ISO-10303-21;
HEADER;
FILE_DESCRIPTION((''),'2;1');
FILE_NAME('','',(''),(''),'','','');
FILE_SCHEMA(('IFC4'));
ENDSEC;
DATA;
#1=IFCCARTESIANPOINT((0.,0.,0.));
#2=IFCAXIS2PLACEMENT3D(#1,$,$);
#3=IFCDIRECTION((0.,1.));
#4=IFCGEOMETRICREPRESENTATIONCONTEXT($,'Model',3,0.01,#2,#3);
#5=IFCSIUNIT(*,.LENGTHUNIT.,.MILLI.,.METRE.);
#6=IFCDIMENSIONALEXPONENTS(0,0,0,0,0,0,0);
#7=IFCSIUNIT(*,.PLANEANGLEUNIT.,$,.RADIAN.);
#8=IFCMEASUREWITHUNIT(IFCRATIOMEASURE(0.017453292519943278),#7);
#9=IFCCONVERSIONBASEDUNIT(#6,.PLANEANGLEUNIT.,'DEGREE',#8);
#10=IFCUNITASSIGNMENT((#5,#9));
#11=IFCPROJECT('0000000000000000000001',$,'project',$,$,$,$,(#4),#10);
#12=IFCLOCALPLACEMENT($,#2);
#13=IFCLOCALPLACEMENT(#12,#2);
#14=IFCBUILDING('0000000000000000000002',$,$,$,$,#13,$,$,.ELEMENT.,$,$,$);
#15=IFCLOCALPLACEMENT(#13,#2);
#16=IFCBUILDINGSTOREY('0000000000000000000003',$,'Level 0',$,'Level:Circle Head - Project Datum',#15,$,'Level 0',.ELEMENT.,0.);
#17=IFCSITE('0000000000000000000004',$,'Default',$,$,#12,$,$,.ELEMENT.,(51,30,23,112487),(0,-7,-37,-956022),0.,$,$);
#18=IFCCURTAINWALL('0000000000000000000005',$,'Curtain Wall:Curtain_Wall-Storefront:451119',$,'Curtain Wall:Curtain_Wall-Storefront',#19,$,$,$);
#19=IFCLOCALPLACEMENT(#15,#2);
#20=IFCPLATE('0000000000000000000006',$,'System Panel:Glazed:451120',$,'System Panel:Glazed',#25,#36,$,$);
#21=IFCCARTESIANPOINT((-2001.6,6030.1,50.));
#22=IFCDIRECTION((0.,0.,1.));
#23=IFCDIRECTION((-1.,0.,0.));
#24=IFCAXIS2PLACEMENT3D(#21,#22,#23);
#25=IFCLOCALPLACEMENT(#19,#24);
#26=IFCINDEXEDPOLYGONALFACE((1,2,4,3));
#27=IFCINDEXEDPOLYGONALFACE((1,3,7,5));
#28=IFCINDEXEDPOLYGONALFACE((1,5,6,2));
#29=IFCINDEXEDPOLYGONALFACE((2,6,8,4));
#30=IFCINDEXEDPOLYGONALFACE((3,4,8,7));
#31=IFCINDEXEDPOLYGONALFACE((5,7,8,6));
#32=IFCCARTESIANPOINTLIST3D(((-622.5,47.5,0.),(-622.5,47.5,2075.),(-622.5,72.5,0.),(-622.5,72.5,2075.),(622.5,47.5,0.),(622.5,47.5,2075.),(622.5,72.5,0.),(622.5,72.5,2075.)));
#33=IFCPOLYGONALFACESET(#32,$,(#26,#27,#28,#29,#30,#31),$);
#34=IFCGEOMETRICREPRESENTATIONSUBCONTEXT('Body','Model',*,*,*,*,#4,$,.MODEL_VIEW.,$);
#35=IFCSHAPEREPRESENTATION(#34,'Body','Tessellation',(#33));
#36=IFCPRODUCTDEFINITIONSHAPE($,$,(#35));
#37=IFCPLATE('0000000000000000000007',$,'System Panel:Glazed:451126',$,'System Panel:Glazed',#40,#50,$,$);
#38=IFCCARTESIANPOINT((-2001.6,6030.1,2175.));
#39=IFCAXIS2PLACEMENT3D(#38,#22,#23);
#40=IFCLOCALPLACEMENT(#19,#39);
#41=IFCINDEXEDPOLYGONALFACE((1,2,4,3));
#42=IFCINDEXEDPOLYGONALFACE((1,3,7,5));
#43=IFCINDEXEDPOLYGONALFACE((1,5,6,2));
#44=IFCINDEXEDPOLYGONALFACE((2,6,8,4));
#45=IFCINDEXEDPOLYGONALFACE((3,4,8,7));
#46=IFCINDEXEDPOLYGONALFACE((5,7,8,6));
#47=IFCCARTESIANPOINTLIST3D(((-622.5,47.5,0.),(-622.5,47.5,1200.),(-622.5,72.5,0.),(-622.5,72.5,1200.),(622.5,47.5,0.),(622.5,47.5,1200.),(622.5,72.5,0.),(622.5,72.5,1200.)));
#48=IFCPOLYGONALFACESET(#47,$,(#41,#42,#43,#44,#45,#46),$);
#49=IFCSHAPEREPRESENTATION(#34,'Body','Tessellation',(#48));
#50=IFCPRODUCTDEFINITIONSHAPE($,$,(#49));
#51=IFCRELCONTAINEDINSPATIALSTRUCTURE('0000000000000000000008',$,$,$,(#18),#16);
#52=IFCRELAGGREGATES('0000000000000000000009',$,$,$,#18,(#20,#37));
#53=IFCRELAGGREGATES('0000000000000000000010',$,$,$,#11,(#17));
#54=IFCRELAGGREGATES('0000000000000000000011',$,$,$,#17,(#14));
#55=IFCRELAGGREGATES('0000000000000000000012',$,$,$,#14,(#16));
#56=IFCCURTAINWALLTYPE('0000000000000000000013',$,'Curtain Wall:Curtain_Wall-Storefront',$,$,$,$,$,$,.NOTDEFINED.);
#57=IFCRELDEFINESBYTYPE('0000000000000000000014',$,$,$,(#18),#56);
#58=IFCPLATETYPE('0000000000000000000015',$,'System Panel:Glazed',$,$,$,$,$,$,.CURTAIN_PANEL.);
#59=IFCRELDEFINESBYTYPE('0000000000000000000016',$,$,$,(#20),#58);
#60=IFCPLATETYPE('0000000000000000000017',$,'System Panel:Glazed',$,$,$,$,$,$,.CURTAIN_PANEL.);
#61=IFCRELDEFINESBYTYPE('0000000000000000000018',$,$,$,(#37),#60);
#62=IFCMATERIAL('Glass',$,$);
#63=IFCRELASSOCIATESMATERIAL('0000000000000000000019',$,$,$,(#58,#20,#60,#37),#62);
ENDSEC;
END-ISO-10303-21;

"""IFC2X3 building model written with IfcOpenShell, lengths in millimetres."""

from ifc_helpers import new_model, entity, si_unit, converted_unit, direction, frame, origin, origin_2d_with_axis, place, context, subcontext, project, spatial, rectangle, extrude, source, transform, mapped, material, type_object, type_shapes, element, aggregate, save


model = new_model("IFC2X3")

# Units and contexts
model_context = context("Model", 3, precision=0.01, world=origin(), true_north=direction((0.0, 1.0)))
body_context = subcontext(model_context, "Body", "Model", "MODEL_VIEW")
ifc_project = project(units=[si_unit("LENGTHUNIT", "METRE", prefix="MILLI"), converted_unit("PLANEANGLEUNIT", "DEGREE", entity("IfcRatioMeasure", 0.017453292519943278), si_unit("PLANEANGLEUNIT", "RADIAN"), dimensions=[0, 0, 0, 0, 0, 0, 0])], contexts=[model_context])

# Site, building, storey
site_placement = place(None, origin())
site = spatial("IfcSite", under=ifc_project, at=site_placement, Name="Default", CompositionType="ELEMENT", RefLatitude=(51, 30, 23, 112487), RefLongitude=(0, -7, -37, -956022), RefElevation=0.0)
building_placement = place(site_placement, origin())
building = spatial("IfcBuilding", under=site, at=building_placement, CompositionType="ELEMENT")
storey_placement = place(building_placement, origin())
storey = spatial("IfcBuildingStorey", under=building, at=storey_placement, Name="Level 0", ObjectType="Level:Circle Head - Project Datum", LongName="Level 0", CompositionType="ELEMENT", Elevation=0.0)

# Curtain wall
curtain_wall_type = type_object("IfcCurtainWallType", Name="Curtain Wall:Curtain_Wall-Storefront", PredefinedType="NOTDEFINED")
curtain_wall_placement = place(storey_placement, origin())
curtain_wall = element("IfcCurtainWall", 1, at=curtain_wall_placement, inside=storey, type_object=curtain_wall_type, Name="Curtain Wall:Curtain_Wall-Storefront:451119", ObjectType="Curtain Wall:Curtain_Wall-Storefront")

# Plates
ifc_material_1 = material(Name="Glass")
plate_type_1 = type_object("IfcPlateType", Name="System Panel:Glazed", PredefinedType="CURTAIN_PANEL", material=ifc_material_1)
shared_shape_1 = source(origin(), body_context, "Body", "SweptSolid", [
    extrude(rectangle(XDim=25.0, YDim=1245.0, at=origin_2d_with_axis()), frame((0.0, 60.0, 0.0), z_axis=(0.0, 0.0, 1.0), x_axis=(0.0, 1.0, 0.0)), (0.0, 0.0, 1.0), 2075.0),
])
type_shapes(plate_type_1, [shared_shape_1])
plate_1_placement = place(curtain_wall_placement, frame((-2001.6, 6030.1, 50.0), z_axis=(0.0, 0.0, 1.0), x_axis=(-1.0, 0.0, 0.0)))
plate_1 = element("IfcPlate", 2, at=plate_1_placement, type_object=plate_type_1, material=ifc_material_1, Name="System Panel:Glazed:451120", ObjectType="System Panel:Glazed", context=body_context, shape_type="MappedRepresentation", body=[
    mapped(shared_shape_1, transform((0.0, 0.0, 0.0), scale=1.0)),
])
plate_type_2 = type_object("IfcPlateType", Name="System Panel:Glazed", PredefinedType="CURTAIN_PANEL", material=ifc_material_1)
shared_shape_2 = source(origin(), body_context, "Body", "SweptSolid", [
    extrude(rectangle(XDim=25.0, YDim=1245.0, at=origin_2d_with_axis()), frame((0.0, 60.0, 0.0), z_axis=(0.0, 0.0, 1.0), x_axis=(0.0, 1.0, 0.0)), (0.0, 0.0, 1.0), 1200.0),
])
type_shapes(plate_type_2, [shared_shape_2])
plate_2_placement = place(curtain_wall_placement, frame((-2001.6, 6030.1, 2175.0), z_axis=(0.0, 0.0, 1.0), x_axis=(-1.0, 0.0, 0.0)))
plate_2 = element("IfcPlate", 3, at=plate_2_placement, type_object=plate_type_2, material=ifc_material_1, Name="System Panel:Glazed:451126", ObjectType="System Panel:Glazed", context=body_context, shape_type="MappedRepresentation", body=[
    mapped(shared_shape_2, transform((0.0, 0.0, 0.0), scale=1.0)),
])
aggregate(curtain_wall, [plate_1, plate_2])

save(model, "model.ifc")
